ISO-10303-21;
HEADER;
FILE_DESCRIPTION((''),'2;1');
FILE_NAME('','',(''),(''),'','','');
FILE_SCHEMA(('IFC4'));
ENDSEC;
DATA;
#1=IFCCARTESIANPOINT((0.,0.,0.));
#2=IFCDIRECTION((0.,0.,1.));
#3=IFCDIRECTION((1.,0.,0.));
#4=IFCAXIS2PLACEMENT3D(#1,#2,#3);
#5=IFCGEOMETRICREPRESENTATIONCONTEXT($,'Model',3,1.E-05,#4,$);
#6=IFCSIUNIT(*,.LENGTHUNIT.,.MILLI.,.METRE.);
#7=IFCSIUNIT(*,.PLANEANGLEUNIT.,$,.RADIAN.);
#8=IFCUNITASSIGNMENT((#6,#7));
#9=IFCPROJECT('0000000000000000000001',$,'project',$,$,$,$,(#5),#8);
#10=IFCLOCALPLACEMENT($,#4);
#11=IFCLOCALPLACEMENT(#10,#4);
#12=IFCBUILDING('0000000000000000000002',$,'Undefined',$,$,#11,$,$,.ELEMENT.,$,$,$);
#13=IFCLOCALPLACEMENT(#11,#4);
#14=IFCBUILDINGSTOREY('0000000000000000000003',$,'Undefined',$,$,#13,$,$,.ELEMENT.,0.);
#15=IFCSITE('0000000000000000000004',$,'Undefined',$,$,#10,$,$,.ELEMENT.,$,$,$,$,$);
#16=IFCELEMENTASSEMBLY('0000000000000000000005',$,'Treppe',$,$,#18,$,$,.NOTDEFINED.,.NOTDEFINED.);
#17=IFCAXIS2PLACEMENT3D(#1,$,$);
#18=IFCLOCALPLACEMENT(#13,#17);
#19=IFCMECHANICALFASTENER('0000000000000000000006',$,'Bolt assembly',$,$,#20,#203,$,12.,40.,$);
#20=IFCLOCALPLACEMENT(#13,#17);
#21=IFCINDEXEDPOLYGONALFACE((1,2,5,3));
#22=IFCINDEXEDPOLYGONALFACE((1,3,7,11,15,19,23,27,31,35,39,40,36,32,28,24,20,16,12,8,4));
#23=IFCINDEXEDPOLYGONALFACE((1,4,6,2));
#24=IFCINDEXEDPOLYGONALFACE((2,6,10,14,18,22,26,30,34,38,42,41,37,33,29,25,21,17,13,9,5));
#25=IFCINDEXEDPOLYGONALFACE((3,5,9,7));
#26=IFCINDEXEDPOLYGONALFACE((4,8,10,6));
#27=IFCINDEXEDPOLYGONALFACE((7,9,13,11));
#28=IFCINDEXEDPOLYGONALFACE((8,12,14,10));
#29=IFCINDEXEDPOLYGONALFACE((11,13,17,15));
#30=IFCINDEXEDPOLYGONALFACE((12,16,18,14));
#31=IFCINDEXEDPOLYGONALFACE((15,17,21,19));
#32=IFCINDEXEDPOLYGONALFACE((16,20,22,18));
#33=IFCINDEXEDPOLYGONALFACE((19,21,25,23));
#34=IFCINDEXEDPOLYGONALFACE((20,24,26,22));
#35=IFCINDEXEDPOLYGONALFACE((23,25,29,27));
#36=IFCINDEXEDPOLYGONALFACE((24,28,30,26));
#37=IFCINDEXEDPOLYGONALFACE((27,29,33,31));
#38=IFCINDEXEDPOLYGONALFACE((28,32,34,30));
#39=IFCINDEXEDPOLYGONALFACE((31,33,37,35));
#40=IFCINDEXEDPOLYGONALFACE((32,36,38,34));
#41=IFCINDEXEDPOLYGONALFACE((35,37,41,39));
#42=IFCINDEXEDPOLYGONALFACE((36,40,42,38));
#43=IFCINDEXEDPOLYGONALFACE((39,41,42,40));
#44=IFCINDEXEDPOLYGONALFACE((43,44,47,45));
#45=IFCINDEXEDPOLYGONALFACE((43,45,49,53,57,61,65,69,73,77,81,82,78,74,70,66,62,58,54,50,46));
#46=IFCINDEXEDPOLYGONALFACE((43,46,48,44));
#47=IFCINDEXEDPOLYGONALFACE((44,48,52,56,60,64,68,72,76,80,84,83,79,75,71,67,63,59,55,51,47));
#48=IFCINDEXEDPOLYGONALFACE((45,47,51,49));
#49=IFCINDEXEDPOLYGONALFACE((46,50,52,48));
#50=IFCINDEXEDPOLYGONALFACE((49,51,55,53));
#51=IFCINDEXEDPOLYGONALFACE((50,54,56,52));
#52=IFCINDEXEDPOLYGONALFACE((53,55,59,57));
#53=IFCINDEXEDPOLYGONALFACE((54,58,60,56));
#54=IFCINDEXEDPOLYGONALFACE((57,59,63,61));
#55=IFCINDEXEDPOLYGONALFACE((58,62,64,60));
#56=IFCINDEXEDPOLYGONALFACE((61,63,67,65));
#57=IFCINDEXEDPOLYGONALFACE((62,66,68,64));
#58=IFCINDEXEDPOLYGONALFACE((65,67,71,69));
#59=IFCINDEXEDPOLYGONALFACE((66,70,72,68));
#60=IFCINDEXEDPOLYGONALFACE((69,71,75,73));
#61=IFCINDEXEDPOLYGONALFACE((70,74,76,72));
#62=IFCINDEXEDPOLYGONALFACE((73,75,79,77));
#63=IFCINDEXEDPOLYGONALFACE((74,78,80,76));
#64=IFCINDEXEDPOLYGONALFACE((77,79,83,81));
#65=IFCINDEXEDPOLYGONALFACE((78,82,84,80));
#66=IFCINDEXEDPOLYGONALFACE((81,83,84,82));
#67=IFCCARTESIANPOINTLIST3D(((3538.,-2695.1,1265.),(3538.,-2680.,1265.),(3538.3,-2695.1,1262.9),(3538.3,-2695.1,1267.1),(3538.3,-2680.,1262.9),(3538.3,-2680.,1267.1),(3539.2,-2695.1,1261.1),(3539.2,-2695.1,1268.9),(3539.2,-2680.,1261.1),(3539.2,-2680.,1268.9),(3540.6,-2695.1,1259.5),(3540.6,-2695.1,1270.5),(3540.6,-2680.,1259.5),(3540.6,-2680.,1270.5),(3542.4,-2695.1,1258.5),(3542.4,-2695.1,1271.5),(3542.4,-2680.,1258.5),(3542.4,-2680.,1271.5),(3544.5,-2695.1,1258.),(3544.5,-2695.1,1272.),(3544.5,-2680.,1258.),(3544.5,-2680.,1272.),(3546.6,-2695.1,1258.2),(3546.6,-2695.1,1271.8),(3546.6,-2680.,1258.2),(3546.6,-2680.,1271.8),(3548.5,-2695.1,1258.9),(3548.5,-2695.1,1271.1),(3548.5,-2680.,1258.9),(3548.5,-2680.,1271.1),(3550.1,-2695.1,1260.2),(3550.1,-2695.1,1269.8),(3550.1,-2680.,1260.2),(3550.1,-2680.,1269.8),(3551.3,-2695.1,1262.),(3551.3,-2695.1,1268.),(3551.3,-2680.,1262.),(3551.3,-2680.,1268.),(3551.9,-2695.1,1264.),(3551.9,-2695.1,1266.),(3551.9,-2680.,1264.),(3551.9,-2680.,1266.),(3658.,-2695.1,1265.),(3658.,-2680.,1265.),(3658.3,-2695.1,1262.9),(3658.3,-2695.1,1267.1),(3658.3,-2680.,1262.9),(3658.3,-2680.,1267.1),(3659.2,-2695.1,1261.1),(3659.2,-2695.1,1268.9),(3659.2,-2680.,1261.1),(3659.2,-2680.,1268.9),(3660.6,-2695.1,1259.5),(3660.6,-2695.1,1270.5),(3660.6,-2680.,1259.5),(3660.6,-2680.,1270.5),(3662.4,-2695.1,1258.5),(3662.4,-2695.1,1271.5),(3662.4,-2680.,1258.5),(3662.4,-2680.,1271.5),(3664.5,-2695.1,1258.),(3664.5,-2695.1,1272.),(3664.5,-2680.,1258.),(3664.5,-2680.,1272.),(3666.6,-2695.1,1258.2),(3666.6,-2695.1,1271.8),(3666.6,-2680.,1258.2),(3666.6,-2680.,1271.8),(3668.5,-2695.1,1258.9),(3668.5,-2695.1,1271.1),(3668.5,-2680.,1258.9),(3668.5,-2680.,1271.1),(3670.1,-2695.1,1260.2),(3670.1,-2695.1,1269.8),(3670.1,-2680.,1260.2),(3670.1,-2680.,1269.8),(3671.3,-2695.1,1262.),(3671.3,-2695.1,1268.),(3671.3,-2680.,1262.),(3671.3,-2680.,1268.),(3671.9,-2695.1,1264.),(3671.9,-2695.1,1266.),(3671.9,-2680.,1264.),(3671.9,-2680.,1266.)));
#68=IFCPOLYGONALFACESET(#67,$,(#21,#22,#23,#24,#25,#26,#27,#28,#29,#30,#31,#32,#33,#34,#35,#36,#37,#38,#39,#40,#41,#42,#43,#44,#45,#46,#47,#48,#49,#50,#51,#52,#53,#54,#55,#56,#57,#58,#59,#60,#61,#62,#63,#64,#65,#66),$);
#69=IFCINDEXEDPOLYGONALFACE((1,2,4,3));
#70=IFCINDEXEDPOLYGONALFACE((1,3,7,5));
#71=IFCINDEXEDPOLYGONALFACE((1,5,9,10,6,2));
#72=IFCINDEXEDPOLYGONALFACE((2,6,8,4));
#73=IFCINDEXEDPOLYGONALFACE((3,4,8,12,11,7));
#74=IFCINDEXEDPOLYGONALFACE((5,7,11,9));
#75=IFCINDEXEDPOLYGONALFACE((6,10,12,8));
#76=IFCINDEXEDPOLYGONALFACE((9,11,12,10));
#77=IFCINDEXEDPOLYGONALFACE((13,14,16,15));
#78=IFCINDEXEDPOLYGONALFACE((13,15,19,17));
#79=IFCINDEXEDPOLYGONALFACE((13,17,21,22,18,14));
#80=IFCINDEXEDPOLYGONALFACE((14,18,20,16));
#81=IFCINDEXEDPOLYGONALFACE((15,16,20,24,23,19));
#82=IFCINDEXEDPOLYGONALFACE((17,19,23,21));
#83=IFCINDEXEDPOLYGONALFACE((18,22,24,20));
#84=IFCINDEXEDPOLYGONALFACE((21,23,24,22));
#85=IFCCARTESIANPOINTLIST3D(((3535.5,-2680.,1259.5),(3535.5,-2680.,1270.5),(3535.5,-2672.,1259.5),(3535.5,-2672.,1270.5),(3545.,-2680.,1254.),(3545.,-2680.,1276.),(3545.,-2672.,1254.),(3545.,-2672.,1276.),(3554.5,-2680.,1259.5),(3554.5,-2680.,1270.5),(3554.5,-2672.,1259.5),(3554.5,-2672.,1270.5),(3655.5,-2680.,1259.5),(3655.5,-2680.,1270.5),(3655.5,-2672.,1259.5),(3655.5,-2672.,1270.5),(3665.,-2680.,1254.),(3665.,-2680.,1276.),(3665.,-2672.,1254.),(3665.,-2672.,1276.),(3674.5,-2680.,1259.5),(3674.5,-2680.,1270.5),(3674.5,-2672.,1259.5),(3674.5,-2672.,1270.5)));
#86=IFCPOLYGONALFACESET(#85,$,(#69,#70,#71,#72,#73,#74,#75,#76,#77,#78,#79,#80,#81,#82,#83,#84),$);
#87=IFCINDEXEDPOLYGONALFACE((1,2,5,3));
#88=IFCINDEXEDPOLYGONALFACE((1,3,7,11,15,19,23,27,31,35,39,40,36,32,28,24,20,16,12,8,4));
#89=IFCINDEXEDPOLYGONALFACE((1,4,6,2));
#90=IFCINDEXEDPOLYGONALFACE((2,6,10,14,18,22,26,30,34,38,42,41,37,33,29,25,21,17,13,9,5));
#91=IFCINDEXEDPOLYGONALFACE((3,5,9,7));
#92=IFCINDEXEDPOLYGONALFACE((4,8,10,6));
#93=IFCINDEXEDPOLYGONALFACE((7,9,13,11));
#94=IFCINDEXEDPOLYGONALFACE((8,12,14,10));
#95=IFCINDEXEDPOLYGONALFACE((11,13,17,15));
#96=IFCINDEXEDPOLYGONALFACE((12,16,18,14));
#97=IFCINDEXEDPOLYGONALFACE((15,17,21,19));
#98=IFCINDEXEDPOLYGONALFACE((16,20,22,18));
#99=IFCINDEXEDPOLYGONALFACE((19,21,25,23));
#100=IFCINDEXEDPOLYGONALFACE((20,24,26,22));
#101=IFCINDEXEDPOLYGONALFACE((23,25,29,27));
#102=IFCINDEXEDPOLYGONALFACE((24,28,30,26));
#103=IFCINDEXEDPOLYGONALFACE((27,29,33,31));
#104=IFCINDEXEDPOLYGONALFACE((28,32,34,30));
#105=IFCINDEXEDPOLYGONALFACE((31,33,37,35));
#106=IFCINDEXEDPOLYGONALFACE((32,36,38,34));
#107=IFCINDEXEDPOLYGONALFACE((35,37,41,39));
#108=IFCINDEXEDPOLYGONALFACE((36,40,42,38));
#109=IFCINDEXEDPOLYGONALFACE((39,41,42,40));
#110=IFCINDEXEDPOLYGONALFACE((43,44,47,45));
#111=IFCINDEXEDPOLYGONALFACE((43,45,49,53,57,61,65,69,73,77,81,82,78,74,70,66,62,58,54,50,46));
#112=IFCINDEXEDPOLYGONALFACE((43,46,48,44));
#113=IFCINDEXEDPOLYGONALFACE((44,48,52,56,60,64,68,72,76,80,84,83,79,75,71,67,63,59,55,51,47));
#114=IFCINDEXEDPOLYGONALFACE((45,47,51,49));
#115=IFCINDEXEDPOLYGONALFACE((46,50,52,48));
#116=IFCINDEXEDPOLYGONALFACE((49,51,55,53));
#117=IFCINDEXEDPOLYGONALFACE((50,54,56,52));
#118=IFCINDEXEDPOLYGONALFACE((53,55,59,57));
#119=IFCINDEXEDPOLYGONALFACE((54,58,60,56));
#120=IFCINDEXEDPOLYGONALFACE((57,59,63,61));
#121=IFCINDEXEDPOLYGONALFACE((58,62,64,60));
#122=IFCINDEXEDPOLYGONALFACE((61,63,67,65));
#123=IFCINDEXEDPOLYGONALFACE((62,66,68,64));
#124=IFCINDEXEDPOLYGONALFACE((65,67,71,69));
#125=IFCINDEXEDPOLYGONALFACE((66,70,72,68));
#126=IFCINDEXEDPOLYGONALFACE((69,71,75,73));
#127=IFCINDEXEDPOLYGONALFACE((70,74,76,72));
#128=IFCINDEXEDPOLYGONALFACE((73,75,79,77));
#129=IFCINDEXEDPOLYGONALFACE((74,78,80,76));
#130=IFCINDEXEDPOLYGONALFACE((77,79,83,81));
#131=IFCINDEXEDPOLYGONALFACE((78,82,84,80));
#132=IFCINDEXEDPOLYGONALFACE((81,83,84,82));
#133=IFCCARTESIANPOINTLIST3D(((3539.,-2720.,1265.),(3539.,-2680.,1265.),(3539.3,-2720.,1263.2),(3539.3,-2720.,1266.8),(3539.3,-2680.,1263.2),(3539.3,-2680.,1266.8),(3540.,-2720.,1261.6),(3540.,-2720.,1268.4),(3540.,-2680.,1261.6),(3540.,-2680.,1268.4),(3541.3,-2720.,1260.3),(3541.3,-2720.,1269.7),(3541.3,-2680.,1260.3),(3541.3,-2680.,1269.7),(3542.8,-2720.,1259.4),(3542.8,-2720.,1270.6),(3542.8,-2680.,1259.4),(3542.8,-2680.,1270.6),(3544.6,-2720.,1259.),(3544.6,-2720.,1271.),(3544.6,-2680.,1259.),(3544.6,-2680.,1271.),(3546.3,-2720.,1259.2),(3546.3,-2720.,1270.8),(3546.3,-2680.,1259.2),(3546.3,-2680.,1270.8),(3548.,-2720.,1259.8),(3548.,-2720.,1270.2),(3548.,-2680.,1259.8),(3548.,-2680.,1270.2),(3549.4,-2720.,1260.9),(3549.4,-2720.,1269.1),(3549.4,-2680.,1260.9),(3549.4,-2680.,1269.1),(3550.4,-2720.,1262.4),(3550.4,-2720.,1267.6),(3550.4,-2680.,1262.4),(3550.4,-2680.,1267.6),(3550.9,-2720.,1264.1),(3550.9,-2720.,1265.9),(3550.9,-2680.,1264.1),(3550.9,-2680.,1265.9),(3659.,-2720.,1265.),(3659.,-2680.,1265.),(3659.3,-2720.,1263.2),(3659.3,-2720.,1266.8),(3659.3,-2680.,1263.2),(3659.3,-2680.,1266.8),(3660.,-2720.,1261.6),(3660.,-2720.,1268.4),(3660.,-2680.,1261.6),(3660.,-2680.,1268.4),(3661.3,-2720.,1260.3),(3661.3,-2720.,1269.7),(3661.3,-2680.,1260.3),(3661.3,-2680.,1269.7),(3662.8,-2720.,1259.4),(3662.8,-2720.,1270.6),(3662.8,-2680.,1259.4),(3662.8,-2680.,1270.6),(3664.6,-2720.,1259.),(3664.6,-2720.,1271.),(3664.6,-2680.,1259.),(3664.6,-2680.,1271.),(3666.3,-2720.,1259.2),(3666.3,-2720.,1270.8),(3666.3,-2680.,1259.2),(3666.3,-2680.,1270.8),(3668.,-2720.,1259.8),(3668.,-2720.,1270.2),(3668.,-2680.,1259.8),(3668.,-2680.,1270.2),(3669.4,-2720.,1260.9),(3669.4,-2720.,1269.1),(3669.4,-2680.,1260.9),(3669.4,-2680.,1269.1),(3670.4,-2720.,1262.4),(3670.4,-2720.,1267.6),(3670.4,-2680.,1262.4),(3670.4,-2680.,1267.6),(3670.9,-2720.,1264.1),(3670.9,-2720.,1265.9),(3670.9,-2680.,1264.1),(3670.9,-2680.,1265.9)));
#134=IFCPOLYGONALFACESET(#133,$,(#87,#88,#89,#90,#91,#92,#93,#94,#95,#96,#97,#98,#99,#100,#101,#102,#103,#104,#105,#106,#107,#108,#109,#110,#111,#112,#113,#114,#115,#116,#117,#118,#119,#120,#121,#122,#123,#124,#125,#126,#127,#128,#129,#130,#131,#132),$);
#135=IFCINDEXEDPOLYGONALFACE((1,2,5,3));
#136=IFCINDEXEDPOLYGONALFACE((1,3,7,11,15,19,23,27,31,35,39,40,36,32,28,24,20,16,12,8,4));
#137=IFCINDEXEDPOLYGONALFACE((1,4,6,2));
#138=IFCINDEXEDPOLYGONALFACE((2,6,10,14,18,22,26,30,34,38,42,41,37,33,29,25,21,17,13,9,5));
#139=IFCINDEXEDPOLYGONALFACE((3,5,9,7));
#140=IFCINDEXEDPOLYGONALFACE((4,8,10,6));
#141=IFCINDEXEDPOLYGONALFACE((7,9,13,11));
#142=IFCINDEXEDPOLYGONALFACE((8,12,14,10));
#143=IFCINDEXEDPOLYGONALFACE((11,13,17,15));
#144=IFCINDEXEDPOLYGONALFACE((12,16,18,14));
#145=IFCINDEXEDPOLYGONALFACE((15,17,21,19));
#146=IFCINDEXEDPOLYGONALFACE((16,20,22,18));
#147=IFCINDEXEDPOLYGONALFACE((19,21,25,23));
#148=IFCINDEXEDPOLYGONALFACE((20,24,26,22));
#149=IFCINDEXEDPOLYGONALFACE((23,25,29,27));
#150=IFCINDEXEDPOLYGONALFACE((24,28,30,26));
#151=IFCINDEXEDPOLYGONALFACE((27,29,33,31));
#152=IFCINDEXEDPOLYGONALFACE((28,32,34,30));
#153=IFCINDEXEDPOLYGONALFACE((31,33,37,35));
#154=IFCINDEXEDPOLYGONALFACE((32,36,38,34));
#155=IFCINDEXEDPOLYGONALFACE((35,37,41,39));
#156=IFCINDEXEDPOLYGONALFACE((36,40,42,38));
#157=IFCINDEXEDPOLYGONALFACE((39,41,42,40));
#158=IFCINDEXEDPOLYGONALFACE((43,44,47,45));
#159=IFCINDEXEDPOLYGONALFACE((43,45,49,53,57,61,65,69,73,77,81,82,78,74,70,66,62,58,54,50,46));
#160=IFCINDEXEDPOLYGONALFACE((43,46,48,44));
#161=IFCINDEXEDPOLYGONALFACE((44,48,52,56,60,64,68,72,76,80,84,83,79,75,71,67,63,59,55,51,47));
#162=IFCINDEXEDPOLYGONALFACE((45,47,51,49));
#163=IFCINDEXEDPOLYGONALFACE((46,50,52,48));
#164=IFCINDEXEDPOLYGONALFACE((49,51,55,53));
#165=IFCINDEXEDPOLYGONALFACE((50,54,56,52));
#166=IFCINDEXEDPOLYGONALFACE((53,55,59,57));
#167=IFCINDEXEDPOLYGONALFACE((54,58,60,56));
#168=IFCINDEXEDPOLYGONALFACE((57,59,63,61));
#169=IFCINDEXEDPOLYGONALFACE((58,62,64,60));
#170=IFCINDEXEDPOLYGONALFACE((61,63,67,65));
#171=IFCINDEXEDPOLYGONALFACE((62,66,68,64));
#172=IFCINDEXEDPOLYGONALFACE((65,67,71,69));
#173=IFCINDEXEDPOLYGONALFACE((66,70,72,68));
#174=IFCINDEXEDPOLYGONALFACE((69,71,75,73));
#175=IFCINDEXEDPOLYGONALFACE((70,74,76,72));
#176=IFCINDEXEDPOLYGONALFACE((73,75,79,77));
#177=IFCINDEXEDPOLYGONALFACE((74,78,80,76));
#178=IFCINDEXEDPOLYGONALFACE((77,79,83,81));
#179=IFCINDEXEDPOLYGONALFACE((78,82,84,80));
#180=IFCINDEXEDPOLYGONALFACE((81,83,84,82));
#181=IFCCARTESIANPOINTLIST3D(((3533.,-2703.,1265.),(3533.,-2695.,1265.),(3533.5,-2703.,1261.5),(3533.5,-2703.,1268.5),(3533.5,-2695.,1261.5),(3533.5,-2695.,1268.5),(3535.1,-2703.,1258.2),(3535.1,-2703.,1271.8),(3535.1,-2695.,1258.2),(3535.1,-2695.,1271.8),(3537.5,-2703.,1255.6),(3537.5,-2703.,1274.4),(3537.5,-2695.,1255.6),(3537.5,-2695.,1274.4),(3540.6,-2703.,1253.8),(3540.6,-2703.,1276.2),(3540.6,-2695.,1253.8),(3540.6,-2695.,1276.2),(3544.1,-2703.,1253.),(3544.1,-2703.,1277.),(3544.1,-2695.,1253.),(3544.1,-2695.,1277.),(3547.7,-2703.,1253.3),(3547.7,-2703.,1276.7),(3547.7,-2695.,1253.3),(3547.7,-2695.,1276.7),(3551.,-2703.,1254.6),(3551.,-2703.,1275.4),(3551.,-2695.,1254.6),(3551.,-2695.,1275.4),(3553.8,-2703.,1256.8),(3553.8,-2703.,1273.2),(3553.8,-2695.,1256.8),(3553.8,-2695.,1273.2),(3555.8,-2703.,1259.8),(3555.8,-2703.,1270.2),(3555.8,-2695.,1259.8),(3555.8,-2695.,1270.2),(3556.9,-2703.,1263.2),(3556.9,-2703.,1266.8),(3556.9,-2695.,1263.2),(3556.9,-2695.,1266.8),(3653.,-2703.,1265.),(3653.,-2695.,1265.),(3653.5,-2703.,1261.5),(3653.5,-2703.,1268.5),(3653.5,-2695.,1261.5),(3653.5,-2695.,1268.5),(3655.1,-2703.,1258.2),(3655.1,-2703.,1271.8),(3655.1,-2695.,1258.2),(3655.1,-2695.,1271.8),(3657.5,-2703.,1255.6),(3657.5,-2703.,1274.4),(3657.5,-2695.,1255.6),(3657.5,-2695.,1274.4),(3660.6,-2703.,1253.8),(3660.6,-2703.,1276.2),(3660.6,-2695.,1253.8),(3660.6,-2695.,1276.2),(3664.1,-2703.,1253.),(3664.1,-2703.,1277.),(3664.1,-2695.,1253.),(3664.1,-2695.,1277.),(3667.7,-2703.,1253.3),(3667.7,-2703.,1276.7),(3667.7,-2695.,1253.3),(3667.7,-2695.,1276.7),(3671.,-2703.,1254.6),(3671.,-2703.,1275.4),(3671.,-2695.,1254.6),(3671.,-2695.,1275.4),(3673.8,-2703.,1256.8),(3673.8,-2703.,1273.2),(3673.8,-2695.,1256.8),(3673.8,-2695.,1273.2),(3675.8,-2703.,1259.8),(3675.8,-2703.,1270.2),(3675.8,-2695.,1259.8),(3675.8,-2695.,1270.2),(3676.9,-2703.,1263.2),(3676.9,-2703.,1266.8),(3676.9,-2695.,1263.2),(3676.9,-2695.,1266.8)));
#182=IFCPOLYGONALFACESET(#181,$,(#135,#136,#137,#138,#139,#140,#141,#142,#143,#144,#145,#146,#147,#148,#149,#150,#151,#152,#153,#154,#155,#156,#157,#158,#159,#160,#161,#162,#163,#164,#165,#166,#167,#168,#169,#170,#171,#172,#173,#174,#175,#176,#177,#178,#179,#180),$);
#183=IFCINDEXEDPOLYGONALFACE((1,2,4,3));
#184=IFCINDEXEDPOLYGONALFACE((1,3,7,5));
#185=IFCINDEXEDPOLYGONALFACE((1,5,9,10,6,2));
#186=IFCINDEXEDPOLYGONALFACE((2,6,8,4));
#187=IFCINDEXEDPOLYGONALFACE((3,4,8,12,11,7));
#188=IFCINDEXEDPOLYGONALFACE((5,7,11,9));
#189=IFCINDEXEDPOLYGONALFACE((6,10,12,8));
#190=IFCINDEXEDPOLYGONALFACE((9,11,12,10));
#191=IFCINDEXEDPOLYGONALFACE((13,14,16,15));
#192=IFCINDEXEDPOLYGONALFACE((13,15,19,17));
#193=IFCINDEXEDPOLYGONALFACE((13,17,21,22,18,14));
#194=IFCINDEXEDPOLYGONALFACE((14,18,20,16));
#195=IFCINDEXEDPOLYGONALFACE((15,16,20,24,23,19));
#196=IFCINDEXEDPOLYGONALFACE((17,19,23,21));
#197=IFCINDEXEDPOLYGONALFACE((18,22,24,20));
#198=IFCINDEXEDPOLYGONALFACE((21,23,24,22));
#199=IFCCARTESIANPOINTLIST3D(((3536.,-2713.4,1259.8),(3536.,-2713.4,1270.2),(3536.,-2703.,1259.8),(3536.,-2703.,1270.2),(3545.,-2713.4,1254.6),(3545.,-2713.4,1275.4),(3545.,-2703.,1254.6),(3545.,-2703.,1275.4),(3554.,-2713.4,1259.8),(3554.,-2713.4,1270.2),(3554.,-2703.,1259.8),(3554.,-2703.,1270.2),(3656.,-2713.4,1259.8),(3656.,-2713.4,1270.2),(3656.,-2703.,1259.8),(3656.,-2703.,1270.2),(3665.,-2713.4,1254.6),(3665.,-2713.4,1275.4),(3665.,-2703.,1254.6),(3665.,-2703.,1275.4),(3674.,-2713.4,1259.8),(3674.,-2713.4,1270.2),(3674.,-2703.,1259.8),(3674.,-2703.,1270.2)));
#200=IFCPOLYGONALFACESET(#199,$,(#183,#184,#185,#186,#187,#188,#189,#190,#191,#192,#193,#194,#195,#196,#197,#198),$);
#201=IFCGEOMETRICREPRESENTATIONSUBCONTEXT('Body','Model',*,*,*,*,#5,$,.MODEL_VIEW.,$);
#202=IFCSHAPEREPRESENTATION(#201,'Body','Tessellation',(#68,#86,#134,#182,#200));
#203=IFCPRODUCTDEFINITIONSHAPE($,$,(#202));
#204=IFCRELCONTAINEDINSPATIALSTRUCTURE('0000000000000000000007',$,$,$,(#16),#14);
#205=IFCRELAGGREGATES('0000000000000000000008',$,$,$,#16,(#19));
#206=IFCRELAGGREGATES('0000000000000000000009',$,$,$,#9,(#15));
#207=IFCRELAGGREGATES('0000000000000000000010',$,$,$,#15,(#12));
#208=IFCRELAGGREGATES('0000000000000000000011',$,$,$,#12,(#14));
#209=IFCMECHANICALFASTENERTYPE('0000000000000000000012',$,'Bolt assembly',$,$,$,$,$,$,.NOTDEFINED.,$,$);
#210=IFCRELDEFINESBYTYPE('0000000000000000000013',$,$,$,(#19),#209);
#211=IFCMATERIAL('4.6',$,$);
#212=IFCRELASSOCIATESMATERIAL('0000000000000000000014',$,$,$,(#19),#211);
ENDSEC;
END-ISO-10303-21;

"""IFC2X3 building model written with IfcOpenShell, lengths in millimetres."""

from ifc_helpers import new_model, si_unit, frame, origin_with_axes, origin_2d_with_axis, place, context, subcontext, project, spatial, polyline, circle, outline, extrude, source, transform, mapped, material, type_object, element, aggregate, save


model = new_model("IFC2X3")

# Units and contexts
model_context = context("Model", 3, precision=1e-05, world=origin_with_axes())
body_context = subcontext(model_context, "Body", "Model", "MODEL_VIEW")
ifc_project = project(units=[si_unit("LENGTHUNIT", "METRE", prefix="MILLI"), si_unit("PLANEANGLEUNIT", "RADIAN")], contexts=[model_context])

# Site, building, storey
site_placement = place(None, origin_with_axes())
site = spatial("IfcSite", under=ifc_project, at=site_placement, Name="Undefined", CompositionType="ELEMENT")
building_placement = place(site_placement, origin_with_axes())
building = spatial("IfcBuilding", under=site, at=building_placement, Name="Undefined", CompositionType="ELEMENT")
storey_placement = place(building_placement, origin_with_axes())
storey = spatial("IfcBuildingStorey", under=building, at=storey_placement, Name="Undefined", CompositionType="ELEMENT", Elevation=0.0)

# Element assembly, mechanical fastener
ifc_material_1 = material(Name="4.6")
mechanical_fastener_type = type_object("IfcMechanicalFastenerType", Name="Bolt assembly")
assembly_1_placement = place(storey_placement, origin_with_axes())
assembly_1 = element("IfcElementAssembly", 1, at=assembly_1_placement, inside=storey, Name="Treppe", AssemblyPlace="NOTDEFINED", PredefinedType="NOTDEFINED")
shared_shape_1 = source(origin_with_axes(), body_context, "Body", "SweptSolid", [
    extrude(circle(Radius=7.0, at=origin_2d_with_axis()), frame((0.0, -15.0, 0.0), z_axis=(0.0, 1.0, 0.0), x_axis=(1.0, 0.0, 0.0)), (0.0, 0.0, 1.0), 15.1),
    extrude(outline(polyline([(9.5, -5.5), (9.5, 5.5), (0.0, 11.0), (-9.5, 5.5), (-9.5, -5.5), (0.0, -11.0), (9.5, -5.5)])), frame((0.0, -23.0, 0.0), z_axis=(0.0, 1.0, 0.0), x_axis=(1.0, 0.0, 0.0)), (0.0, 0.0, 1.0), 8.0),
    extrude(circle(Radius=6.0, at=origin_2d_with_axis()), frame((0.0, -15.0, 0.0), z_axis=(0.0, 1.0, 0.0), x_axis=(1.0, 0.0, 0.0)), (0.0, 0.0, 1.0), 40.0),
    extrude(circle(Radius=12.0, at=origin_2d_with_axis()), frame((0.0, 0.0, 0.0), z_axis=(0.0, 1.0, 0.0), x_axis=(1.0, 0.0, 0.0)), (0.0, 0.0, 1.0), 8.0),
    extrude(outline(polyline([(9.0, -5.2), (9.0, 5.2), (0.0, 10.4), (-9.0, 5.2), (-9.0, -5.2), (0.0, -10.4), (9.0, -5.2)])), frame((0.0, 8.0, 0.0), z_axis=(0.0, 1.0, 0.0), x_axis=(1.0, 0.0, 0.0)), (0.0, 0.0, 1.0), 10.4),
])
mechanical_fastener_1_placement = place(assembly_1_placement, frame((3665.0, -2695.0, 1265.0), z_axis=(0.0, 0.0, 1.0), x_axis=(-1.0, 0.0, 0.0)))
mechanical_fastener_1 = element("IfcMechanicalFastener", 2, at=mechanical_fastener_1_placement, type_object=mechanical_fastener_type, material=ifc_material_1, Name="Bolt assembly", NominalDiameter=12.0, NominalLength=40.0, context=body_context, shape_type="MappedRepresentation", body=[
    mapped(shared_shape_1, transform((0.0, 0.0, 0.0))),
    mapped(shared_shape_1, transform((120.0, 0.0, 0.0))),
])
aggregate(assembly_1, [mechanical_fastener_1])

save(model, "model.ifc")
